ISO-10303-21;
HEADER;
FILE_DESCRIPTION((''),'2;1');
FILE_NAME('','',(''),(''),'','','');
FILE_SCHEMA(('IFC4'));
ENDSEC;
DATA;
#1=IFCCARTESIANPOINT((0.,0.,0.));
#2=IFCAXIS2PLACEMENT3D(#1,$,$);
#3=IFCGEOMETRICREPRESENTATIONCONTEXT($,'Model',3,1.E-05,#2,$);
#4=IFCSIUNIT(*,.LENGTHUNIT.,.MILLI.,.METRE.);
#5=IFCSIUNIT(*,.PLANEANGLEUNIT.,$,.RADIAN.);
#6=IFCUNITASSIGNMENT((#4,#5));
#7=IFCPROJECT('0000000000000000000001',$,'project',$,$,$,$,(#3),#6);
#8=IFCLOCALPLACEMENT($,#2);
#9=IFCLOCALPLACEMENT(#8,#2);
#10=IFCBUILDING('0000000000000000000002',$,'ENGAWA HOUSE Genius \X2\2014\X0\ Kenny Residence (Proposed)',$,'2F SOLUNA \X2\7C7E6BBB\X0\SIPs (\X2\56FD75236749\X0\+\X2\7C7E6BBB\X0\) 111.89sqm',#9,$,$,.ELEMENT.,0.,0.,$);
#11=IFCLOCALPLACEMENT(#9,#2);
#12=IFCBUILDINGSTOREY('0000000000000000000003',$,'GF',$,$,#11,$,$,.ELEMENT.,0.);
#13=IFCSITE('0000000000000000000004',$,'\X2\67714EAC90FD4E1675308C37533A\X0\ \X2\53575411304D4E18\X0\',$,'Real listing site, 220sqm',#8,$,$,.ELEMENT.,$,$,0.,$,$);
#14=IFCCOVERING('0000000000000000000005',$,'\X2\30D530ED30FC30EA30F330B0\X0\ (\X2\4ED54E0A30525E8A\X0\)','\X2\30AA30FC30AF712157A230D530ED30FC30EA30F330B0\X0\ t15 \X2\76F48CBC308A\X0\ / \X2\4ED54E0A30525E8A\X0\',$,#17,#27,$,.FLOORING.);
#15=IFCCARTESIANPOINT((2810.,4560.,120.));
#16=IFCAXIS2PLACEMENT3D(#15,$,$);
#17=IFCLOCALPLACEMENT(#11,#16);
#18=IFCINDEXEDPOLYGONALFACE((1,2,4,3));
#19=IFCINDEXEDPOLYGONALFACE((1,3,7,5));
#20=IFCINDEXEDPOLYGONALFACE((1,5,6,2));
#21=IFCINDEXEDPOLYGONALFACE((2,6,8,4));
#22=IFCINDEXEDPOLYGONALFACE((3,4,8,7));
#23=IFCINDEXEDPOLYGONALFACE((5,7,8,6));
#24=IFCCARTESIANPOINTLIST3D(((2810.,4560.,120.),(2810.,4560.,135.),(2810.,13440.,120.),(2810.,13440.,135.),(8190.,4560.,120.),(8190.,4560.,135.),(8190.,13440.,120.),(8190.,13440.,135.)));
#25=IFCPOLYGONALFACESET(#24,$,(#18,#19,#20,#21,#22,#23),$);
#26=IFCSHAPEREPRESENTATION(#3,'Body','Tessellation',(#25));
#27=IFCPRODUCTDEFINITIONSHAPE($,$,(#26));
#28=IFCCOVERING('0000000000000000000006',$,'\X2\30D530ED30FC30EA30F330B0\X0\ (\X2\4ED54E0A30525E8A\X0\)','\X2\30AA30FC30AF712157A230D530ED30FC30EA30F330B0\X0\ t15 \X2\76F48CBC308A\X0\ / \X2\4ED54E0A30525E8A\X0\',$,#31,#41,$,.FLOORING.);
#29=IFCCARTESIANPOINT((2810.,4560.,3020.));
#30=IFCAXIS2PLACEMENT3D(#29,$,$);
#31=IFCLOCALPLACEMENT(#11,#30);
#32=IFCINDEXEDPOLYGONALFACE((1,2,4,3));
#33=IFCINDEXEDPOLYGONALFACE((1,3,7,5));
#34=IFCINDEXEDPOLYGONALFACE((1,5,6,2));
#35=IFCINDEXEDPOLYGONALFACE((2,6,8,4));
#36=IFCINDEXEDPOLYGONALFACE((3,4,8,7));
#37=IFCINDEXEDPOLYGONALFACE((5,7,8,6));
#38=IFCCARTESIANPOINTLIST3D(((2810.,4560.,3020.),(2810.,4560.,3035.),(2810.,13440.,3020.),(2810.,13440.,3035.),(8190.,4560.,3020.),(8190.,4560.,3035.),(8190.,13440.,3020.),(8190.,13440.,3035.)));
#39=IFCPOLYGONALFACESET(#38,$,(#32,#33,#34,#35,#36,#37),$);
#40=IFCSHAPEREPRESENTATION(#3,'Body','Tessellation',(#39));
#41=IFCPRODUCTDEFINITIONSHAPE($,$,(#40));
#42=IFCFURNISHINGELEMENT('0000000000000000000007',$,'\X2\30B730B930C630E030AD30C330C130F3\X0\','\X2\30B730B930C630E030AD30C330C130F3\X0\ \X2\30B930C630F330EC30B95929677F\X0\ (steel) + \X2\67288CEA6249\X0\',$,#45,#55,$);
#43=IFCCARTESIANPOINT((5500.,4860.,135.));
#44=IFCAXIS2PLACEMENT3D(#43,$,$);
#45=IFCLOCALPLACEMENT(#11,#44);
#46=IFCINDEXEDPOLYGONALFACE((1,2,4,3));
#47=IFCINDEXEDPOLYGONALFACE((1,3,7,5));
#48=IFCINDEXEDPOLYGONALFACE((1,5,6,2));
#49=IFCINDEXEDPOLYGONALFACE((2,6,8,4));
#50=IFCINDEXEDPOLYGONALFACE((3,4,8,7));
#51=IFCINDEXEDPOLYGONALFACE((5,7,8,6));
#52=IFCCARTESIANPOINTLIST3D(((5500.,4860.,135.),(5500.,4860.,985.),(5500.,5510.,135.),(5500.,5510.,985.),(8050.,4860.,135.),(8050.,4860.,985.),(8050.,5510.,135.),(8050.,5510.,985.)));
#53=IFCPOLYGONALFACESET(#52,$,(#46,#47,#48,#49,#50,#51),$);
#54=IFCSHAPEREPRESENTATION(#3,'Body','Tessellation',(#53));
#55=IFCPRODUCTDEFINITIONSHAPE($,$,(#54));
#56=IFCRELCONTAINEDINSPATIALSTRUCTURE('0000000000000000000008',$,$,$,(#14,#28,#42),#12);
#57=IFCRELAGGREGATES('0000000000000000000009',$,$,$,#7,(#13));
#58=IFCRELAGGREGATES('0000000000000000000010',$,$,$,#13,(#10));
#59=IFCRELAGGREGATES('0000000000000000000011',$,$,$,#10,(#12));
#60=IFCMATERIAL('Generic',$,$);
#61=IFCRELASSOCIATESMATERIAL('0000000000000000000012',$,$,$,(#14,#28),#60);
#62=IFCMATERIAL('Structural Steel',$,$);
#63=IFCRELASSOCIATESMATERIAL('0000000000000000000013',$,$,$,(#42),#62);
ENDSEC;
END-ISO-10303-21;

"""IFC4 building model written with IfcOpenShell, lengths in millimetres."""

from ifc_helpers import new_model, si_unit, frame, frame_2d, origin, place, context, project, spatial, rectangle, extrude, material, element, save


model = new_model("IFC4")

# Units and contexts
model_context = context("Model", 3, precision=1e-05, world=origin())
ifc_project = project(units=[si_unit("LENGTHUNIT", "METRE", prefix="MILLI"), si_unit("PLANEANGLEUNIT", "RADIAN")], contexts=[model_context])

# Site, building, storey
site_placement = place(None, origin())
site = spatial("IfcSite", under=ifc_project, at=site_placement, Name="東京都世田谷区 南向き丘", ObjectType="Real listing site, 220sqm", CompositionType="ELEMENT", RefElevation=0.0)
building_placement = place(site_placement, origin())
building = spatial("IfcBuilding", under=site, at=building_placement, Name="ENGAWA HOUSE Genius — Kenny Residence (Proposed)", ObjectType="2F SOLUNA 籾殻SIPs (国産杉+籾殻) 111.89sqm", CompositionType="ELEMENT", ElevationOfRefHeight=0.0, ElevationOfTerrain=0.0)
storey_placement = place(building_placement, origin())
storey = spatial("IfcBuildingStorey", under=building, at=storey_placement, Name="GF", CompositionType="ELEMENT", Elevation=0.0)

# Shared definitions
ifc_material_1 = material(Name="Generic")

# Shared definitions
ifc_material_2 = material(Name="Structural Steel")

# Coverings
covering_1_placement = place(storey_placement, frame((2810.0, 4560.0, 120.0)))
element("IfcCovering", 1, at=covering_1_placement, inside=storey, material=ifc_material_1, Name="フローリング (仕上げ床)", Description="オーク無垢フローリング t15 直貼り / 仕上げ床", PredefinedType="FLOORING", context=model_context, shape_type="SweptSolid", body=[
    extrude(rectangle(XDim=5380.0, YDim=8880.0, at=frame_2d((2690.0, 4440.0))), frame((2810.0, 4560.0, 120.0)), (0.0, 0.0, 1.0), 15.0),
])
covering_2_placement = place(storey_placement, frame((2810.0, 4560.0, 3020.0)))
element("IfcCovering", 2, at=covering_2_placement, inside=storey, material=ifc_material_1, Name="フローリング (仕上げ床)", Description="オーク無垢フローリング t15 直貼り / 仕上げ床", PredefinedType="FLOORING", context=model_context, shape_type="SweptSolid", body=[
    extrude(rectangle(XDim=5380.0, YDim=8880.0, at=frame_2d((2690.0, 4440.0))), frame((2810.0, 4560.0, 3020.0)), (0.0, 0.0, 1.0), 15.0),
])

# Furnishing element
furnishing_placement = place(storey_placement, frame((5500.0, 4860.0, 135.0)))
element("IfcFurnishingElement", 3, at=furnishing_placement, inside=storey, material=ifc_material_2, Name="システムキッチン", Description="システムキッチン ステンレス天板 (steel) + 木質扉", context=model_context, shape_type="SweptSolid", body=[
    extrude(rectangle(XDim=2550.0, YDim=650.0, at=frame_2d((1275.0, 325.0))), frame((5500.0, 4860.0, 135.0)), (0.0, 0.0, 1.0), 850.0),
])

save(model, "model.ifc")
